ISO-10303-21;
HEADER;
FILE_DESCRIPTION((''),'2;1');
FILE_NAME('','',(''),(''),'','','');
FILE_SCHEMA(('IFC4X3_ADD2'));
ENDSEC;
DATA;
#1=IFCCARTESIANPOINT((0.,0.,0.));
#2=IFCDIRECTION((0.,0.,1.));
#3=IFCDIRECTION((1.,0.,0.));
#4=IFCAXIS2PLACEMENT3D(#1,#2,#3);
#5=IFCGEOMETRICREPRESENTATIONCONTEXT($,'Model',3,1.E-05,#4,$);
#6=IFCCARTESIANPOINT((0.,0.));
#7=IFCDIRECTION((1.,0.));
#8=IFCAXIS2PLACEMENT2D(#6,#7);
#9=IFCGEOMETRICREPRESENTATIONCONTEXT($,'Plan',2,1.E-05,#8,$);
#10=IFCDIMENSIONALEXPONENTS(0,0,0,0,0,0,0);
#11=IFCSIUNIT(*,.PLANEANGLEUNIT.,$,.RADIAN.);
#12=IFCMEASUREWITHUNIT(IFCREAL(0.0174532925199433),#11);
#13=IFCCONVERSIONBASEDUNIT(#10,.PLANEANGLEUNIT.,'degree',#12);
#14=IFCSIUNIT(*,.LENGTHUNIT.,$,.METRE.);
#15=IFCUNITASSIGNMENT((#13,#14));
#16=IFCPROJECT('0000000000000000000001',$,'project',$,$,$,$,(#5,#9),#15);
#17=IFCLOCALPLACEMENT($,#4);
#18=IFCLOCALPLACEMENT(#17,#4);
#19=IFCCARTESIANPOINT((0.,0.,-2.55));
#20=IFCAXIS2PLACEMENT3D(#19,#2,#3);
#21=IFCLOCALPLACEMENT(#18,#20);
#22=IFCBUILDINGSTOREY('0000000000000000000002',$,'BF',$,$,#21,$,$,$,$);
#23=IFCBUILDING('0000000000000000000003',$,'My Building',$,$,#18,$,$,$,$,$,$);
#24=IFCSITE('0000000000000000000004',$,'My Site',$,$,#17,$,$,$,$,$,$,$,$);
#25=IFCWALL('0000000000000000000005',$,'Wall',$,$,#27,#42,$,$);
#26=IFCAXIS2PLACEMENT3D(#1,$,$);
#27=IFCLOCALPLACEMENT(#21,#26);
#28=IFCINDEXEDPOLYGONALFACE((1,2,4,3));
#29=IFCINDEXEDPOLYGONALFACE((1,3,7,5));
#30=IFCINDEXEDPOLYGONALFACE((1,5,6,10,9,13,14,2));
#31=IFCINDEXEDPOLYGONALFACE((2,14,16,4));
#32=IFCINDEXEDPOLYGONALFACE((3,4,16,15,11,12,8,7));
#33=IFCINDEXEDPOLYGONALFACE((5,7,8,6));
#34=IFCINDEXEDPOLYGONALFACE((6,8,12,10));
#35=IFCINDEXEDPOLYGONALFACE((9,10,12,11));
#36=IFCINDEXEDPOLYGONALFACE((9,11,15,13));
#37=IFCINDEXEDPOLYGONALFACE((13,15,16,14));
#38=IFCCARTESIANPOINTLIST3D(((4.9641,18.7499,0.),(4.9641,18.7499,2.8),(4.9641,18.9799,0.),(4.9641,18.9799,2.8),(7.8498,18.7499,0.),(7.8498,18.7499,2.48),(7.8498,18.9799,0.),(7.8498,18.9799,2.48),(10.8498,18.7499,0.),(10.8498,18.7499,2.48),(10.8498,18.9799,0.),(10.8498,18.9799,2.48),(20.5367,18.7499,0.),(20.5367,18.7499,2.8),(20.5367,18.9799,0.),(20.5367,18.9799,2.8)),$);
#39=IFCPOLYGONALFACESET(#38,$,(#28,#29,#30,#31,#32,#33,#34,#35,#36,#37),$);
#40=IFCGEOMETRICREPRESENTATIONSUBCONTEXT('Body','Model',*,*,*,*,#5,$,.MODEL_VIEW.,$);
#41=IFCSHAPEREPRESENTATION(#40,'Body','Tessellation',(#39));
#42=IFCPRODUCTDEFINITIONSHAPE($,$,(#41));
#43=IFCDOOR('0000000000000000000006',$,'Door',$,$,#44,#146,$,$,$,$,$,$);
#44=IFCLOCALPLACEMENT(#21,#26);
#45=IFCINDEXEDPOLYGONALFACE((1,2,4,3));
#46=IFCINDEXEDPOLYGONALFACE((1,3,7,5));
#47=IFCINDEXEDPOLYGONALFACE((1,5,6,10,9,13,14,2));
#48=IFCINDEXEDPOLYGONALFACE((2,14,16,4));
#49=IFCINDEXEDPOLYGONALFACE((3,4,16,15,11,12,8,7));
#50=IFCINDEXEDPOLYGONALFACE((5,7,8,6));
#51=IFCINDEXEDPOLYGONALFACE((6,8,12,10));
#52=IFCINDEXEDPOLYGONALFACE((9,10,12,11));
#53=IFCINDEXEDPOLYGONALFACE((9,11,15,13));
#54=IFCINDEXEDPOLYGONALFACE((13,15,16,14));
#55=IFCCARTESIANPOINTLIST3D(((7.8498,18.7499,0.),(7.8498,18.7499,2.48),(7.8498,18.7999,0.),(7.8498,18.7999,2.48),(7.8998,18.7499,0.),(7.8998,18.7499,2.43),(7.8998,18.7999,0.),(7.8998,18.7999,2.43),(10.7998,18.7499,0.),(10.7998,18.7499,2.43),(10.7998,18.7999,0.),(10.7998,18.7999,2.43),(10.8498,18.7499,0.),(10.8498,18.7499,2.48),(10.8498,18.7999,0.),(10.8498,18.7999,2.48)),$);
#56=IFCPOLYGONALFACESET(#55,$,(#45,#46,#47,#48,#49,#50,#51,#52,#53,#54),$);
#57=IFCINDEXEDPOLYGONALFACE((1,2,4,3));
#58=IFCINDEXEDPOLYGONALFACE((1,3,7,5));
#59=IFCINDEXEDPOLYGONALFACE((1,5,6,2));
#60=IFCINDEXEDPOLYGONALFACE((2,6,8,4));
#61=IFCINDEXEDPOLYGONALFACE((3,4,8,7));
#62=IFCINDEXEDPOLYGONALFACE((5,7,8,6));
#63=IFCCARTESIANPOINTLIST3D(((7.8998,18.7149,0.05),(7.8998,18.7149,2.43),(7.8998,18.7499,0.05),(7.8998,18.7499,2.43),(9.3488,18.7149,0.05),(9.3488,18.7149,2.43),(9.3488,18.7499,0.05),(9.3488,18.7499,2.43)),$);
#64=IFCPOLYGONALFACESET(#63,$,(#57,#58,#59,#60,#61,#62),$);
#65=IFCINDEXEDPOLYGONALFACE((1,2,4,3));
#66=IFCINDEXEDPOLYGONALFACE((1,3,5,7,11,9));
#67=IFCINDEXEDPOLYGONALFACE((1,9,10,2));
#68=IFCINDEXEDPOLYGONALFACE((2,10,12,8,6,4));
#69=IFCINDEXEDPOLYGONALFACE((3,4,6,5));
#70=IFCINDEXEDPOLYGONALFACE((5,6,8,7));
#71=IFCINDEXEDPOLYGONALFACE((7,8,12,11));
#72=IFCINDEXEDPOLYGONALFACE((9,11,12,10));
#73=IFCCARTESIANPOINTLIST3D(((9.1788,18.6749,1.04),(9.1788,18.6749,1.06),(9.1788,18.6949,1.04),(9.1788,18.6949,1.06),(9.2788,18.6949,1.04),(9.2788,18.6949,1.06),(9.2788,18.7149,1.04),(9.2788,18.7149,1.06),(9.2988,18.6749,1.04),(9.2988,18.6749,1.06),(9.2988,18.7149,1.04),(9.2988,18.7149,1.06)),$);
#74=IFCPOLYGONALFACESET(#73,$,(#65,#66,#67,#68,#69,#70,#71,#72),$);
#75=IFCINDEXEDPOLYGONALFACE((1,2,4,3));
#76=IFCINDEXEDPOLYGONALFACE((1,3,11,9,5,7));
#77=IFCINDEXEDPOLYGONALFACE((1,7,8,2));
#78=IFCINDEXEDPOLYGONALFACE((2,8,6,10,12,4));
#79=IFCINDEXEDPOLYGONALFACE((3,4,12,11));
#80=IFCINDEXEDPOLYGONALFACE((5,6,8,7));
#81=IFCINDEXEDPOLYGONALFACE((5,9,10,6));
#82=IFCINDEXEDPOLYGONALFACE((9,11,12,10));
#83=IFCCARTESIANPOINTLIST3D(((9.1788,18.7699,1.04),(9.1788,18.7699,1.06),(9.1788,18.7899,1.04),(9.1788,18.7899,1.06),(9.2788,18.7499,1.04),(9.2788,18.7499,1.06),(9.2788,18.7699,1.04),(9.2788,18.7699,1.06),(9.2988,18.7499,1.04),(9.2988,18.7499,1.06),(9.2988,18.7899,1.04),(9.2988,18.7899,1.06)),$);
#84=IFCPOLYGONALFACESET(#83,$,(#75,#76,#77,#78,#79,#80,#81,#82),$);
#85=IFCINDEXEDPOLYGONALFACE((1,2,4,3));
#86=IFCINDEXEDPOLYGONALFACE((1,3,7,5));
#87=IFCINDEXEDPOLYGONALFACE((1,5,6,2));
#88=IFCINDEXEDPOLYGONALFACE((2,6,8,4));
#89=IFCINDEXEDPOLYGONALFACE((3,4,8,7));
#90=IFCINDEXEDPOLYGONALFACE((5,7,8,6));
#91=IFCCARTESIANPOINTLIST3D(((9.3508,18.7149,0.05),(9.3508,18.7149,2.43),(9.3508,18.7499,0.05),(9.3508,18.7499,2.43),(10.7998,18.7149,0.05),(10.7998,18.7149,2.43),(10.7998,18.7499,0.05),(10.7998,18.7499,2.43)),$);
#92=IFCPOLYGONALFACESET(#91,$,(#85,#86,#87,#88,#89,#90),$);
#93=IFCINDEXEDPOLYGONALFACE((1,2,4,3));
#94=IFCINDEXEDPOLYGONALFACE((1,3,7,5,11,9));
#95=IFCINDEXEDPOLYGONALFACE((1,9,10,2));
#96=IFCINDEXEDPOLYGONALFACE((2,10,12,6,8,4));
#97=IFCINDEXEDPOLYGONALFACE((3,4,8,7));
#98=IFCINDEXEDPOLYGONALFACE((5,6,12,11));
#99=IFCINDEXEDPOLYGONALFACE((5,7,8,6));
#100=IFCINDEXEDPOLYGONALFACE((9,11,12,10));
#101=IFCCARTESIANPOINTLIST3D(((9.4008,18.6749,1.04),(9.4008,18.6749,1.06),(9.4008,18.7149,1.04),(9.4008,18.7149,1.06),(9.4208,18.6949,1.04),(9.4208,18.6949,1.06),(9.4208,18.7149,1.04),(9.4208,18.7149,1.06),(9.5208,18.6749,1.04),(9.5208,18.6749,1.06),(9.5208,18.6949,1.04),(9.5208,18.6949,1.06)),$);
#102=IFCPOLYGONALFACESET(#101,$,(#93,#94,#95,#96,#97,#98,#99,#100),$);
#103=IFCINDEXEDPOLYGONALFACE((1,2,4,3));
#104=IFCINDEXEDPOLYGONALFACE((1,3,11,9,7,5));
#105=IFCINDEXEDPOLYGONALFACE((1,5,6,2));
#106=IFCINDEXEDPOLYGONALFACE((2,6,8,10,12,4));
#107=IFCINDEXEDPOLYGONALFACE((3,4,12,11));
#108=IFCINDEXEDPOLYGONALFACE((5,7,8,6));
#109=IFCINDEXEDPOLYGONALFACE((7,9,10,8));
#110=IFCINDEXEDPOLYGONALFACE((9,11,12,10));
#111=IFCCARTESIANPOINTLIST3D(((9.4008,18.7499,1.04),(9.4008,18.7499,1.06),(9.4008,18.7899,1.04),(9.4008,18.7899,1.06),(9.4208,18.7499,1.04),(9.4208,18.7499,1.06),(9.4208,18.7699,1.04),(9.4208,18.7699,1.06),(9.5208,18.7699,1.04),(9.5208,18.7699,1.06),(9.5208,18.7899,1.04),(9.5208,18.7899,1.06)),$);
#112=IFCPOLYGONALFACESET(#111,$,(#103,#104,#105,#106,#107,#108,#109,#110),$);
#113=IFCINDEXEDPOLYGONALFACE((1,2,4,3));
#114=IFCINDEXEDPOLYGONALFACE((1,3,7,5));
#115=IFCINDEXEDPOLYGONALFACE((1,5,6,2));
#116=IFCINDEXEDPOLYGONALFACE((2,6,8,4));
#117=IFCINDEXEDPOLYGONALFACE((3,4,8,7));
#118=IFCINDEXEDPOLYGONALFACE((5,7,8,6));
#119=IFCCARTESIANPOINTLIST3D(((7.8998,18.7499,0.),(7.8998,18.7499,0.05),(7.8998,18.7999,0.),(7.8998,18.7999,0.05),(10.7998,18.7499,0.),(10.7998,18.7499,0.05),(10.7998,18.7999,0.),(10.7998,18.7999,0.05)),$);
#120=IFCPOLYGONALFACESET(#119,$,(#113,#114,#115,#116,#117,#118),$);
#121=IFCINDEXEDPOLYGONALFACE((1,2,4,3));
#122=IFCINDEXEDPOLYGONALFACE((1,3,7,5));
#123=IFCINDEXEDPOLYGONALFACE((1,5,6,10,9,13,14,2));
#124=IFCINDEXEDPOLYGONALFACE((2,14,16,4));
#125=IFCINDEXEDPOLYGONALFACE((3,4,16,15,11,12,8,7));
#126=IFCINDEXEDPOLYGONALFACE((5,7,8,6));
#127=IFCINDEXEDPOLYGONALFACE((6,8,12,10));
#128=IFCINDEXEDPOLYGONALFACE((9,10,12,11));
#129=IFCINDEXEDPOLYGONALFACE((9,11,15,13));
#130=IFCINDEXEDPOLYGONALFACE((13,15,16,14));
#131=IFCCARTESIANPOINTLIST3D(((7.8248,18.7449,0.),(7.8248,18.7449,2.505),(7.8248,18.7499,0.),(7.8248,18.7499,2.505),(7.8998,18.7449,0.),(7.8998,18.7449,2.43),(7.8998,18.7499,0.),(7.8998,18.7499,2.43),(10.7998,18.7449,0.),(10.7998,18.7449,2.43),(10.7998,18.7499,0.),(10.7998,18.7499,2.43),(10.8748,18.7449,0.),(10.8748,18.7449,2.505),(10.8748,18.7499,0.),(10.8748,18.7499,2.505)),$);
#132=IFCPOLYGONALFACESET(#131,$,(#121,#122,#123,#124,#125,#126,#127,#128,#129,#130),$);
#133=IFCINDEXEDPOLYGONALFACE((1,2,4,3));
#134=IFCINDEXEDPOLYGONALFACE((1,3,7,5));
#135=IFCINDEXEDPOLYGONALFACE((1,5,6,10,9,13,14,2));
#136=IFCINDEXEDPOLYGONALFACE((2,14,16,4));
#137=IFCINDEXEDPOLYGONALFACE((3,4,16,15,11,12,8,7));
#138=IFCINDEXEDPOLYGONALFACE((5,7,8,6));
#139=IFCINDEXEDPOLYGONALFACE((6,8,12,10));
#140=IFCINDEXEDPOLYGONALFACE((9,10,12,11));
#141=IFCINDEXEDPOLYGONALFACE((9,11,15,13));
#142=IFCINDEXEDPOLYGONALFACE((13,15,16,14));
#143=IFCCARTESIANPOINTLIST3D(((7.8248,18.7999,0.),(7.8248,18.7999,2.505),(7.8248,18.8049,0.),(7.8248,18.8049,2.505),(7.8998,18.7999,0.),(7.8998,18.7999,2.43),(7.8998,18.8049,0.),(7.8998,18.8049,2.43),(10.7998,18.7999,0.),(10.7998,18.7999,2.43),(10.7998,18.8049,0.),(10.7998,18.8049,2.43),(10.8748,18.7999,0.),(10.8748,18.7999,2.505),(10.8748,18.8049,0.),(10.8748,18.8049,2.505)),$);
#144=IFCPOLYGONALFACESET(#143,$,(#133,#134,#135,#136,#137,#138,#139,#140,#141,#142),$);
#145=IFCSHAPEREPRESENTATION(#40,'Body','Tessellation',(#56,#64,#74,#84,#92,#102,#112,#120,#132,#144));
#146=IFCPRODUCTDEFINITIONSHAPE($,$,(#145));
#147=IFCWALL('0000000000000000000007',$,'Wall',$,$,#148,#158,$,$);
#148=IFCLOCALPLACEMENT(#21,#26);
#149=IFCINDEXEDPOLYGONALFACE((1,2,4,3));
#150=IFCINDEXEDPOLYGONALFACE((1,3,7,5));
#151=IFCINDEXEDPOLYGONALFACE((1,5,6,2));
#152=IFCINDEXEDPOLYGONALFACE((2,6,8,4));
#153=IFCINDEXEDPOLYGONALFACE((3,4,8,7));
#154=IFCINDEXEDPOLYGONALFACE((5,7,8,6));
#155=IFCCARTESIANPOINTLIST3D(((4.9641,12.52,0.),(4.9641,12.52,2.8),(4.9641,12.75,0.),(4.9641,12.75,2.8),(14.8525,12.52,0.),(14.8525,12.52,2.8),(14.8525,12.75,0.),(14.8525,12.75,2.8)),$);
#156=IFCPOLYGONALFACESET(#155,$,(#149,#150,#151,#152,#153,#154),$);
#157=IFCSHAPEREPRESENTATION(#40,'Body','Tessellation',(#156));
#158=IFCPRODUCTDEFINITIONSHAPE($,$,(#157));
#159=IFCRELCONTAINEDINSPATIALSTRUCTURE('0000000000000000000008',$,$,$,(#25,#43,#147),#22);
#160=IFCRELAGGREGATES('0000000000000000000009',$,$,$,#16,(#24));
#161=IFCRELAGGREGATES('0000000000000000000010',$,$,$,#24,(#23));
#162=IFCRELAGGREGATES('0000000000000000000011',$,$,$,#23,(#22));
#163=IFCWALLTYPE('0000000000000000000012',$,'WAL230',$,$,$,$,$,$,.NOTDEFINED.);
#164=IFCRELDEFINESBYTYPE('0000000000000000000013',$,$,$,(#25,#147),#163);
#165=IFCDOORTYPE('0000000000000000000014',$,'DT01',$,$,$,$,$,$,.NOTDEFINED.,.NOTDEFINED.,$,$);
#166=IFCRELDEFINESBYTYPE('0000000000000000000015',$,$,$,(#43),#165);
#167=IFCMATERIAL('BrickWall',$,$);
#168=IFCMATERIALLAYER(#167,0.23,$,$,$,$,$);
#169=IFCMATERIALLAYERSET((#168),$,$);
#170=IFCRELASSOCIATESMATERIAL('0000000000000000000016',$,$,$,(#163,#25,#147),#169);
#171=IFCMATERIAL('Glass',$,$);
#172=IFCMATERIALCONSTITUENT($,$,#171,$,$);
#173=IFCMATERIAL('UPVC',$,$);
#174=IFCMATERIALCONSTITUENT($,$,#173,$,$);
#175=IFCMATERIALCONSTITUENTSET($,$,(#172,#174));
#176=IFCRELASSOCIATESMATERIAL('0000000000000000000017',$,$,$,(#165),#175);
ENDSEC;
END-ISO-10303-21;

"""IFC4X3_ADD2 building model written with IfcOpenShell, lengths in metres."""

from ifc_helpers import new_model, entity, si_unit, converted_unit, frame, origin_with_axes, origin_2d_with_axis, place, context, subcontext, project, spatial, line, indexed_curve, outline, extrude, shape, source, transform, mapped, material, layer, layer_set, layer_usage, constituent, constituent_set, type_object, type_shapes, element, fill, save


model = new_model("IFC4X3_ADD2")

# Units and contexts
model_context = context("Model", 3, precision=1e-05, world=origin_with_axes())
plan_context = context("Plan", 2, precision=1e-05, world=origin_2d_with_axis())
body_context_1 = subcontext(model_context, "Body", "Model", "MODEL_VIEW")
body_context_2 = subcontext(plan_context, "Body", "Plan", "PLAN_VIEW")
ifc_project = project(units=[converted_unit("PLANEANGLEUNIT", "degree", entity("IfcReal", 0.0174532925199433), si_unit("PLANEANGLEUNIT", "RADIAN"), dimensions=[0, 0, 0, 0, 0, 0, 0]), si_unit("LENGTHUNIT", "METRE")], contexts=[model_context, plan_context])

# Site, building, storey
site_placement = place(None, origin_with_axes())
site = spatial("IfcSite", under=ifc_project, at=site_placement, Name="My Site")
building_placement = place(site_placement, origin_with_axes())
building = spatial("IfcBuilding", under=site, at=building_placement, Name="My Building")
storey_placement = place(building_placement, frame((0.0, 0.0, -2.55), z_axis=(0.0, 0.0, 1.0), x_axis=(1.0, 0.0, 0.0)))
storey = spatial("IfcBuildingStorey", under=building, at=storey_placement, Name="BF")

# Shared definitions
ifc_material_1 = material(Name="BrickWall")

# Shared definitions
ifc_layer_1 = layer(ifc_material_1, 0.23)
ifc_layer_set_1 = layer_set([ifc_layer_1])
wall_type = type_object("IfcWallType", Name="WAL230", PredefinedType="NOTDEFINED", material=ifc_layer_set_1)
wall_1_placement = place(storey_placement, frame((0.23, 18.7499, 0.0), z_axis=(0.0, 0.0, 1.0), x_axis=(1.0, 0.0, 0.0)))
shared_shape_1 = source(origin_with_axes(), body_context_1, "Body", "SweptSolid", [
    extrude(outline(indexed_curve([(0.0, 0.0), (3.0, 0.0), (3.0, 2.48), (0.0, 2.48)], segments=[line(1, 2, 3, 4, 1)])), frame((0.0, -0.6, 0.0), z_axis=(0.0, -1.0, 0.0), x_axis=(1.0, 0.0, 0.0)), (0.0, 0.0, -1.0), 1.2),
])
ifc_material_2 = material(Name="Glass")
ifc_constituent_1 = constituent(ifc_material_2)
ifc_material_3 = material(Name="UPVC")
ifc_constituent_2 = constituent(ifc_material_3)
ifc_constituent_set = constituent_set(constituents=[ifc_constituent_1, ifc_constituent_2])
door_type = type_object("IfcDoorType", Name="DT01", OperationType="NOTDEFINED", PredefinedType="NOTDEFINED", material=ifc_constituent_set)
shared_shape_2 = source(origin_with_axes(), body_context_1, "Body", "SweptSolid", [
    extrude(outline(indexed_curve([(3.0, 0.0), (3.0, 2.48), (0.0, 2.48), (0.0, 0.0), (0.05, 0.0), (0.05, 2.43), (2.95, 2.43), (2.95, 0.0)], segments=[line(5, 4), line(4, 3), line(3, 2), line(2, 1), line(1, 8), line(8, 7), line(7, 6), line(6, 5)], self_intersect=False)), frame((0.0, 0.0, 0.0), z_axis=(0.0, -1.0, 0.0), x_axis=(1.0, 0.0, 0.0)), (0.0, 0.0, -1.0), 0.05),
    extrude(outline(indexed_curve([(0.0, 0.0), (1.449, 0.0), (1.449, 0.035), (0.0, 0.035)], segments=[line(1, 2, 3, 4, 1)])), frame((0.05, -0.035, 0.05), z_axis=(0.0, 0.0, 1.0), x_axis=(1.0, 0.0, 0.0)), (0.0, 0.0, 1.0), 2.38),
    extrude(outline(indexed_curve([(0.0, 0.0), (0.0, -0.04), (-0.12, -0.04), (-0.12, -0.02), (-0.02, -0.02), (-0.02, 0.0)], segments=[line(1, 2, 3, 4, 5, 6, 1)])), frame((1.449, -0.035, 1.04), z_axis=(0.0, 0.0, 1.0), x_axis=(1.0, 0.0, 0.0)), (0.0, 0.0, 1.0), 0.02),
    extrude(outline(indexed_curve([(0.0, 0.0), (0.0, 0.04), (-0.12, 0.04), (-0.12, 0.02), (-0.02, 0.02), (-0.02, 0.0)], segments=[line(1, 2, 3, 4, 5, 6, 1)])), frame((1.449, 0.0, 1.04), z_axis=(0.0, 0.0, 1.0), x_axis=(1.0, 0.0, 0.0)), (0.0, 0.0, 1.0), 0.02),
    extrude(outline(indexed_curve([(0.0, 0.0), (-1.449, 0.0), (-1.449, 0.035), (0.0, 0.035)], segments=[line(1, 2, 3, 4, 1)])), frame((2.95, -0.035, 0.05), z_axis=(0.0, 0.0, 1.0), x_axis=(1.0, 0.0, 0.0)), (0.0, 0.0, 1.0), 2.38),
    extrude(outline(indexed_curve([(0.0, 0.0), (0.0, -0.04), (0.12, -0.04), (0.12, -0.02), (0.02, -0.02), (0.02, 0.0)], segments=[line(1, 2, 3, 4, 5, 6, 1)])), frame((1.551, -0.035, 1.04), z_axis=(0.0, 0.0, 1.0), x_axis=(1.0, 0.0, 0.0)), (0.0, 0.0, 1.0), 0.02),
    extrude(outline(indexed_curve([(0.0, 0.0), (0.0, 0.04), (0.12, 0.04), (0.12, 0.02), (0.02, 0.02), (0.02, 0.0)], segments=[line(1, 2, 3, 4, 5, 6, 1)])), frame((1.551, 0.0, 1.04), z_axis=(0.0, 0.0, 1.0), x_axis=(1.0, 0.0, 0.0)), (0.0, 0.0, 1.0), 0.02),
    extrude(outline(indexed_curve([(0.0, 0.0), (2.9, 0.0), (2.9, 0.05), (0.0, 0.05)], segments=[line(1, 2, 3, 4, 1)])), frame((0.05, 0.0, 0.0), z_axis=(0.0, 0.0, 1.0), x_axis=(1.0, 0.0, 0.0)), (0.0, 0.0, 1.0), 0.05),
    extrude(outline(indexed_curve([(0.0, 0.0), (0.0, 2.505), (3.05, 2.505), (3.05, 0.0), (2.975, 0.0), (2.975, 2.43), (0.075, 2.43), (0.075, 0.0)], segments=[line(1, 2, 3, 4, 5, 6, 7, 8, 1)])), frame((-0.025, -0.005, 0.0), z_axis=(0.0, -1.0, 0.0), x_axis=(1.0, 0.0, 0.0)), (0.0, 0.0, -1.0), 0.005),
    extrude(outline(indexed_curve([(0.0, 0.0), (0.0, 2.505), (3.05, 2.505), (3.05, 0.0), (2.975, 0.0), (2.975, 2.43), (0.075, 2.43), (0.075, 0.0)], segments=[line(1, 2, 3, 4, 5, 6, 7, 8, 1)])), frame((-0.025, 0.05, 0.0), z_axis=(0.0, -1.0, 0.0), x_axis=(1.0, 0.0, 0.0)), (0.0, 0.0, -1.0), 0.005),
])
shared_shape_3 = source(origin_with_axes(), body_context_2, "Body", "Curve2D", [
    entity("IfcIndexedPolyCurve", entity("IfcCartesianPointList2D", [[0.0, 0.0], [0.05, 0.0], [0.05, 0.05], [0.0, 0.05]]), [entity("IfcLineIndex", [1, 2, 3, 4, 1])]),
    entity("IfcIndexedPolyCurve", entity("IfcCartesianPointList2D", [[3.0, 0.0], [2.95, 0.0], [2.95, 0.05], [3.0, 0.05]]), [entity("IfcLineIndex", [1, 2, 3, 4, 1])]),
    entity("IfcIndexedPolyCurve", entity("IfcCartesianPointList2D", [[-0.675, -0.035], [0.775, -0.035], [0.775, 0.0], [-0.675, 0.0]]), [entity("IfcLineIndex", [1, 2, 3, 4, 1])]),
    entity("IfcIndexedPolyCurve", entity("IfcCartesianPointList2D", [[3.675, -0.035], [2.225, -0.035], [2.225, 0.0], [3.675, 0.0]]), [entity("IfcLineIndex", [1, 2, 3, 4, 1])]),
])
type_shapes(door_type, [shared_shape_2, shared_shape_3])

# Wall, opening, door
ifc_layer_usage_1 = layer_usage(ifc_layer_set_1, "AXIS2", "POSITIVE", 0.0)
wall_2_placement = place(storey_placement, frame((4.9641, 18.7499, 0.0), z_axis=(0.0, 0.0, 1.0), x_axis=(1.0, 0.0, 0.0)))
wall_2 = element("IfcWall", 1, at=wall_2_placement, inside=storey, type_object=wall_type, material=ifc_layer_usage_1, Name="Wall", context=body_context_1, shape_type="SweptSolid", body=[
    extrude(outline(indexed_curve([(0.0, 0.0), (0.0, 0.23), (15.5727, 0.23), (15.5727, 0.0), (0.0, 0.0)], self_intersect=False)), origin_with_axes(), (0.0, 0.0, 1.0), 2.8),
])
opening_1_placement = place(wall_2_placement, frame((2.8857, 0.0, 0.0), z_axis=(0.0, 0.0, 1.0), x_axis=(1.0, 0.0, 0.0)))
opening_1 = element("IfcOpeningElement", 2, at=opening_1_placement, cuts=wall_2, PredefinedType="OPENING", context=body_context_1, shape_type="MappedRepresentation", body=[
    mapped(shared_shape_1, transform((0.0, 0.0, 0.0), x_axis=(1.0, 0.0, 0.0), y_axis=(0.0, 1.0, 0.0), z_axis=(0.0, 0.0, 1.0), scale=1.0)),
])
placement = place(wall_1_placement, frame((7.6198, 0.0, 0.0), z_axis=(0.0, 0.0, 1.0), x_axis=(1.0, 0.0, 0.0)))
door_1_placement = place(placement, origin_with_axes())
door_1 = element("IfcDoor", 3, at=door_1_placement, inside=storey, type_object=door_type, Name="Door", shapes=[
    shape(body_context_1, "Body", "MappedRepresentation", [mapped(shared_shape_2, transform((0.0, 0.0, 0.0), x_axis=(1.0, 0.0, 0.0), y_axis=(0.0, 1.0, 0.0), z_axis=(0.0, 0.0, 1.0), scale=1.0))]),
    shape(body_context_2, "Body", "MappedRepresentation", [mapped(shared_shape_3, transform((0.0, 0.0, 0.0), x_axis=(1.0, 0.0, 0.0), y_axis=(0.0, 1.0, 0.0), z_axis=(0.0, 0.0, 1.0), scale=1.0))]),
])
fill(opening_1, door_1)

# Wall
ifc_layer_usage_2 = layer_usage(ifc_layer_set_1, "AXIS2", "POSITIVE", 0.0)
wall_3_placement = place(storey_placement, frame((4.9641, 12.52, 0.0), z_axis=(0.0, 0.0, 1.0), x_axis=(1.0, 0.0, 0.0)))
element("IfcWall", 4, at=wall_3_placement, inside=storey, type_object=wall_type, material=ifc_layer_usage_2, Name="Wall", context=body_context_1, shape_type="SweptSolid", body=[
    extrude(outline(indexed_curve([(0.0, 0.0), (0.0, 0.23), (9.8884, 0.23), (9.8884, 0.0), (0.0, 0.0)], self_intersect=False)), origin_with_axes(), (0.0, 0.0, 1.0), 2.8),
])

save(model, "model.ifc")
